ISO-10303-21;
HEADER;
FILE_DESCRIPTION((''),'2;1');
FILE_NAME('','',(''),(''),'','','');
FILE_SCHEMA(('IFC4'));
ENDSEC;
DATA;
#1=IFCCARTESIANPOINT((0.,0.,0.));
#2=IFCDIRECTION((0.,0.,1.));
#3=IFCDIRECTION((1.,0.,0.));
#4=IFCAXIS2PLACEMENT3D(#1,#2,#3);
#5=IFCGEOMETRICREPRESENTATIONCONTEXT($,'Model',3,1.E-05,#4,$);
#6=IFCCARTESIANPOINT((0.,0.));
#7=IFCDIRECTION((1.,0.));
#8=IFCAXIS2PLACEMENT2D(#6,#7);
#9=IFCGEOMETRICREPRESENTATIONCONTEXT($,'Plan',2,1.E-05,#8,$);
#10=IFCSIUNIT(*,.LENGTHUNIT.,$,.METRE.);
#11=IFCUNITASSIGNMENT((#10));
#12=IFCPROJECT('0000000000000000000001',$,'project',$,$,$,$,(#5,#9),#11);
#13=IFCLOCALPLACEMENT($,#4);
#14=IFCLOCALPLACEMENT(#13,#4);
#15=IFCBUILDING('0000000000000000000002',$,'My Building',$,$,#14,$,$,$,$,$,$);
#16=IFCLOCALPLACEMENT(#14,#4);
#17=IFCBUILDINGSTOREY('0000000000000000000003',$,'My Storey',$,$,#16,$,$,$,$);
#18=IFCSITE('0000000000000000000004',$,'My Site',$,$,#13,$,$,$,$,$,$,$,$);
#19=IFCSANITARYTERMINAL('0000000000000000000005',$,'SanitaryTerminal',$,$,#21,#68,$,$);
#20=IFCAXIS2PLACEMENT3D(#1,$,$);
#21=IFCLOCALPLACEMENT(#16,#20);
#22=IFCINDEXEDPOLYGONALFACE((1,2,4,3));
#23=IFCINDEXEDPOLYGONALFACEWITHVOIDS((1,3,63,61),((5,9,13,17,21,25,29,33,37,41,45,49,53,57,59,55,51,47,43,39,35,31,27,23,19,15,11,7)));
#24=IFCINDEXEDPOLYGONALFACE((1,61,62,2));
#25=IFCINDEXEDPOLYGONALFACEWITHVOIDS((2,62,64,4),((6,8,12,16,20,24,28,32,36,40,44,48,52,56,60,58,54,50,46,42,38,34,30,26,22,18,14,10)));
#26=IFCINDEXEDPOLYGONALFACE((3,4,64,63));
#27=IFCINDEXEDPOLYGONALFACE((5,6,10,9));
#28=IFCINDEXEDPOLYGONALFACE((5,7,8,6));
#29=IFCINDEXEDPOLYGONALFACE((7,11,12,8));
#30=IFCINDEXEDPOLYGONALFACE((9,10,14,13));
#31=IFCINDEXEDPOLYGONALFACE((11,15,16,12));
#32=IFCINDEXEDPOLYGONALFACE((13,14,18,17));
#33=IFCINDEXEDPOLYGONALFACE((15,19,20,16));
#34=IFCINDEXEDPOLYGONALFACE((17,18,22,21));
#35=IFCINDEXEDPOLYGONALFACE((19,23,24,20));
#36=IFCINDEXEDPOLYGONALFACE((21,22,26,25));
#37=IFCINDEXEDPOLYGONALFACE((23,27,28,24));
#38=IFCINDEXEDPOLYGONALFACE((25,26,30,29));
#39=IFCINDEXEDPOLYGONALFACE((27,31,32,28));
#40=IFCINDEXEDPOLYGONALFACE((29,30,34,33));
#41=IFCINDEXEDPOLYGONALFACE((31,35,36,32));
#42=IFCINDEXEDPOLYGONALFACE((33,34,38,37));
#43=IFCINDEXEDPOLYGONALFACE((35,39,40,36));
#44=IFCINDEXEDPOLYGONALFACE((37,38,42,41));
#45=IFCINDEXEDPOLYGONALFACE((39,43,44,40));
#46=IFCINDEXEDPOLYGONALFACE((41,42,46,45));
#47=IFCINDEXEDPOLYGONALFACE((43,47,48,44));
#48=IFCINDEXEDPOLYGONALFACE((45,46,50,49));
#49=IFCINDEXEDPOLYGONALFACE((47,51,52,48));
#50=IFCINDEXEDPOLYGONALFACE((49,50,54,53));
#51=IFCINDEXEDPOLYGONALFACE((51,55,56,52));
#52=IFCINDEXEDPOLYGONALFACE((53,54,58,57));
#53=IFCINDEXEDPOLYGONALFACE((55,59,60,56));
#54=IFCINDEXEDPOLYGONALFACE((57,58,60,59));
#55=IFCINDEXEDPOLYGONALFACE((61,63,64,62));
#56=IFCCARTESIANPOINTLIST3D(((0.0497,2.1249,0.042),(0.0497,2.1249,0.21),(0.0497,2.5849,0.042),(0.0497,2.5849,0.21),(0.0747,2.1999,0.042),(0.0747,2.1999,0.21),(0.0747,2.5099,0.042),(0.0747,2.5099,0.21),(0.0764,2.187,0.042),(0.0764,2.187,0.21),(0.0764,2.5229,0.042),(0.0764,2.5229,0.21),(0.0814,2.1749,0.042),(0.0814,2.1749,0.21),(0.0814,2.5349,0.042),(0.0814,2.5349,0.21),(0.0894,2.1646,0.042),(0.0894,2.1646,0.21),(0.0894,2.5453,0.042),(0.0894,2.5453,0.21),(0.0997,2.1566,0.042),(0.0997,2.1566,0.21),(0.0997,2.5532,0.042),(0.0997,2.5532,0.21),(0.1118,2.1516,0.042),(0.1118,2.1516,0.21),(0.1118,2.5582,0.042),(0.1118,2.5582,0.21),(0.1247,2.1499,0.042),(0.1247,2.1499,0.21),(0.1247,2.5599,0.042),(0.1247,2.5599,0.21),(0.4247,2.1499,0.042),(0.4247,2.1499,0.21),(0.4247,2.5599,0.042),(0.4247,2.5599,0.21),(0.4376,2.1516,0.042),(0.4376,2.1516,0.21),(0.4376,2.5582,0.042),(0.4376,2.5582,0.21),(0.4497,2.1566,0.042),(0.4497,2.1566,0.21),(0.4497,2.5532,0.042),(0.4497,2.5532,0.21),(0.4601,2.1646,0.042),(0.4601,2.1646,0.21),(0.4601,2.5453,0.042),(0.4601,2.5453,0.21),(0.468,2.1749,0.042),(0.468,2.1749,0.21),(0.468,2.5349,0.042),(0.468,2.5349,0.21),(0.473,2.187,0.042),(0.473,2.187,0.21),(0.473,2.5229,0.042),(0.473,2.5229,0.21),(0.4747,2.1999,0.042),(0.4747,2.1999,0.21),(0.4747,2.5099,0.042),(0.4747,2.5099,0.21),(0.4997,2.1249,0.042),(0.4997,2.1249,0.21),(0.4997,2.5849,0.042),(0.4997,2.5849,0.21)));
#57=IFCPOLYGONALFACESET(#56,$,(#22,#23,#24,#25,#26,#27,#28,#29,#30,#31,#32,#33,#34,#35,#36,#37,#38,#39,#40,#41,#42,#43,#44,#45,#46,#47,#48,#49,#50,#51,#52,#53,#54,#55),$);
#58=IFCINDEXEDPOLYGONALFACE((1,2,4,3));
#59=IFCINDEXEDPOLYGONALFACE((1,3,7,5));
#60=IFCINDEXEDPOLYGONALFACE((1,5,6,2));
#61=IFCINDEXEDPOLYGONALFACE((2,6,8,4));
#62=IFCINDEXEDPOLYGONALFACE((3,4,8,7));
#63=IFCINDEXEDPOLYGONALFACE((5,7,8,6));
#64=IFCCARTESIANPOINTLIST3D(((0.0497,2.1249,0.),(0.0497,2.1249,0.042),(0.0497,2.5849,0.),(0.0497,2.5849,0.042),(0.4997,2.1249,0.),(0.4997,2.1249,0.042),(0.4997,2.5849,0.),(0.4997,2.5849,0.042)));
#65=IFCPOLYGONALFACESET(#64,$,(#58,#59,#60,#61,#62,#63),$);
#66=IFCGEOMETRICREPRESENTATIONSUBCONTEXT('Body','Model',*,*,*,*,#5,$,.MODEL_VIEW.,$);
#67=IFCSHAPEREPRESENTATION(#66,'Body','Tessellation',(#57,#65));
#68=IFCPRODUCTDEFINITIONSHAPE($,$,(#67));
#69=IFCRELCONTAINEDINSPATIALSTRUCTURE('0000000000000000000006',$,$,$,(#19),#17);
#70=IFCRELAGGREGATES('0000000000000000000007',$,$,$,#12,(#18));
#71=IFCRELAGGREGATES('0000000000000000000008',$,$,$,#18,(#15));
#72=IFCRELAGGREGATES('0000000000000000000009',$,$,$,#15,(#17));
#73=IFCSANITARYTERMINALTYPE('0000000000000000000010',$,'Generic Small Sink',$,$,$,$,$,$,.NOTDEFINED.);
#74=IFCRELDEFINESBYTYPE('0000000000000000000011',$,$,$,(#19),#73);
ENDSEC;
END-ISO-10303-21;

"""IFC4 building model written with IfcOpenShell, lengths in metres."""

from ifc_helpers import new_model, entity, si_unit, frame, origin_with_axes, origin_2d_with_axis, place, context, subcontext, project, spatial, shape, source, transform, mapped, type_object, type_shapes, element, save


model = new_model("IFC4")

# Units and contexts
model_context = context("Model", 3, precision=1e-05, world=origin_with_axes())
plan_context = context("Plan", 2, precision=1e-05, world=origin_2d_with_axis())
body_context_1 = subcontext(model_context, "Body", "Model", "MODEL_VIEW")
body_context_2 = subcontext(plan_context, "Body", "Plan", "PLAN_VIEW")
ifc_project = project(units=[si_unit("LENGTHUNIT", "METRE")], contexts=[model_context, plan_context])

# Site, building, storey
site_placement = place(None, origin_with_axes())
site = spatial("IfcSite", under=ifc_project, at=site_placement, Name="My Site")
building_placement = place(site_placement, origin_with_axes())
building = spatial("IfcBuilding", under=site, at=building_placement, Name="My Building")
storey_placement = place(building_placement, origin_with_axes())
storey = spatial("IfcBuildingStorey", under=building, at=storey_placement, Name="My Storey")

# Sanitary terminal
sanitary_terminal_type = type_object("IfcSanitaryTerminalType", Name="Generic Small Sink", PredefinedType="NOTDEFINED")
shared_indexed_poly_curve = entity("IfcIndexedPolyCurve", entity("IfcCartesianPointList2D", [[0.0, 0.0], [0.45, 0.0], [0.45, 0.46], [0.0, 0.46]]), [entity("IfcLineIndex", [1, 2, 3, 4, 1])])
shared_shape_1 = source(origin_with_axes(), body_context_1, "Body", "SweptSolid", [
    entity("IfcExtrudedAreaSolid", entity("IfcArbitraryProfileDefWithVoids", "AREA", None, shared_indexed_poly_curve, [entity("IfcIndexedPolyCurve", entity("IfcCartesianPointList2D", [[0.025, 0.075], [0.0396, 0.0396], [0.075, 0.025], [0.375, 0.025], [0.4104, 0.0396], [0.425, 0.075], [0.425, 0.385], [0.4104, 0.4204], [0.375, 0.435], [0.075, 0.435], [0.0396, 0.4204], [0.025, 0.385]]), [entity("IfcLineIndex", [12, 1]), entity("IfcArcIndex", [1, 2, 3]), entity("IfcLineIndex", [3, 4]), entity("IfcArcIndex", [4, 5, 6]), entity("IfcLineIndex", [6, 7]), entity("IfcArcIndex", [7, 8, 9]), entity("IfcLineIndex", [9, 10]), entity("IfcArcIndex", [10, 11, 12]), entity("IfcLineIndex", [12, 1])])]), entity("IfcAxis2Placement3D", entity("IfcCartesianPoint", [-0.225, -0.46, 0.042]), entity("IfcDirection", [0.0, 0.0, 1.0]), entity("IfcDirection", [1.0, 0.0, 0.0])), entity("IfcDirection", [0.0, 0.0, 1.0]), 0.168),
    entity("IfcExtrudedAreaSolid", entity("IfcArbitraryClosedProfileDef", "AREA", None, shared_indexed_poly_curve), entity("IfcAxis2Placement3D", entity("IfcCartesianPoint", [-0.225, -0.46, 0.0]), entity("IfcDirection", [0.0, 0.0, 1.0]), entity("IfcDirection", [1.0, 0.0, 0.0])), entity("IfcDirection", [0.0, 0.0, 1.0]), 0.042),
])
shared_shape_2 = source(origin_with_axes(), body_context_2, "Body", "Curve2D", [
    entity("IfcIndexedPolyCurve", entity("IfcCartesianPointList2D", [[-0.225, -0.46], [0.225, -0.46], [0.225, 0.0], [-0.225, 0.0]]), [entity("IfcLineIndex", [1, 2, 3, 4, 1])]),
    entity("IfcIndexedPolyCurve", entity("IfcCartesianPointList2D", [[-0.2, -0.385], [-0.1854, -0.4204], [-0.15, -0.435], [0.15, -0.435], [0.1854, -0.4204], [0.2, -0.385], [0.2, -0.075], [0.1854, -0.0396], [0.15, -0.025], [-0.15, -0.025], [-0.1854, -0.0396], [-0.2, -0.075]]), [entity("IfcLineIndex", [12, 1]), entity("IfcArcIndex", [1, 2, 3]), entity("IfcLineIndex", [3, 4]), entity("IfcArcIndex", [4, 5, 6]), entity("IfcLineIndex", [6, 7]), entity("IfcArcIndex", [7, 8, 9]), entity("IfcLineIndex", [9, 10]), entity("IfcArcIndex", [10, 11, 12]), entity("IfcLineIndex", [12, 1])]),
    entity("IfcCircle", entity("IfcAxis2Placement2D", entity("IfcCartesianPoint", [0.0, -0.125])), 0.025),
    entity("IfcIndexedPolyCurve", entity("IfcCartesianPointList2D", [[0.0, -0.0125], [0.0, -0.1325]])),
])
type_shapes(sanitary_terminal_type, [shared_shape_1, shared_shape_2])
sanitary_terminal_placement = place(storey_placement, frame((0.2747, 2.5849, 0.0), z_axis=(0.0, 0.0, 1.0), x_axis=(1.0, 0.0, 0.0)))
element("IfcSanitaryTerminal", 1, at=sanitary_terminal_placement, inside=storey, type_object=sanitary_terminal_type, Name="SanitaryTerminal", shapes=[
    shape(body_context_1, "Body", "MappedRepresentation", [mapped(shared_shape_1, transform((0.0, 0.0, 0.0), x_axis=(1.0, 0.0, 0.0), y_axis=(0.0, 1.0, 0.0), z_axis=(0.0, 0.0, 1.0), scale=1.0))]),
    shape(body_context_2, "Body", "MappedRepresentation", [mapped(shared_shape_2, transform((0.0, 0.0, 0.0), x_axis=(1.0, 0.0, 0.0), y_axis=(0.0, 1.0, 0.0), z_axis=(0.0, 0.0, 1.0), scale=1.0))]),
])

save(model, "model.ifc")
